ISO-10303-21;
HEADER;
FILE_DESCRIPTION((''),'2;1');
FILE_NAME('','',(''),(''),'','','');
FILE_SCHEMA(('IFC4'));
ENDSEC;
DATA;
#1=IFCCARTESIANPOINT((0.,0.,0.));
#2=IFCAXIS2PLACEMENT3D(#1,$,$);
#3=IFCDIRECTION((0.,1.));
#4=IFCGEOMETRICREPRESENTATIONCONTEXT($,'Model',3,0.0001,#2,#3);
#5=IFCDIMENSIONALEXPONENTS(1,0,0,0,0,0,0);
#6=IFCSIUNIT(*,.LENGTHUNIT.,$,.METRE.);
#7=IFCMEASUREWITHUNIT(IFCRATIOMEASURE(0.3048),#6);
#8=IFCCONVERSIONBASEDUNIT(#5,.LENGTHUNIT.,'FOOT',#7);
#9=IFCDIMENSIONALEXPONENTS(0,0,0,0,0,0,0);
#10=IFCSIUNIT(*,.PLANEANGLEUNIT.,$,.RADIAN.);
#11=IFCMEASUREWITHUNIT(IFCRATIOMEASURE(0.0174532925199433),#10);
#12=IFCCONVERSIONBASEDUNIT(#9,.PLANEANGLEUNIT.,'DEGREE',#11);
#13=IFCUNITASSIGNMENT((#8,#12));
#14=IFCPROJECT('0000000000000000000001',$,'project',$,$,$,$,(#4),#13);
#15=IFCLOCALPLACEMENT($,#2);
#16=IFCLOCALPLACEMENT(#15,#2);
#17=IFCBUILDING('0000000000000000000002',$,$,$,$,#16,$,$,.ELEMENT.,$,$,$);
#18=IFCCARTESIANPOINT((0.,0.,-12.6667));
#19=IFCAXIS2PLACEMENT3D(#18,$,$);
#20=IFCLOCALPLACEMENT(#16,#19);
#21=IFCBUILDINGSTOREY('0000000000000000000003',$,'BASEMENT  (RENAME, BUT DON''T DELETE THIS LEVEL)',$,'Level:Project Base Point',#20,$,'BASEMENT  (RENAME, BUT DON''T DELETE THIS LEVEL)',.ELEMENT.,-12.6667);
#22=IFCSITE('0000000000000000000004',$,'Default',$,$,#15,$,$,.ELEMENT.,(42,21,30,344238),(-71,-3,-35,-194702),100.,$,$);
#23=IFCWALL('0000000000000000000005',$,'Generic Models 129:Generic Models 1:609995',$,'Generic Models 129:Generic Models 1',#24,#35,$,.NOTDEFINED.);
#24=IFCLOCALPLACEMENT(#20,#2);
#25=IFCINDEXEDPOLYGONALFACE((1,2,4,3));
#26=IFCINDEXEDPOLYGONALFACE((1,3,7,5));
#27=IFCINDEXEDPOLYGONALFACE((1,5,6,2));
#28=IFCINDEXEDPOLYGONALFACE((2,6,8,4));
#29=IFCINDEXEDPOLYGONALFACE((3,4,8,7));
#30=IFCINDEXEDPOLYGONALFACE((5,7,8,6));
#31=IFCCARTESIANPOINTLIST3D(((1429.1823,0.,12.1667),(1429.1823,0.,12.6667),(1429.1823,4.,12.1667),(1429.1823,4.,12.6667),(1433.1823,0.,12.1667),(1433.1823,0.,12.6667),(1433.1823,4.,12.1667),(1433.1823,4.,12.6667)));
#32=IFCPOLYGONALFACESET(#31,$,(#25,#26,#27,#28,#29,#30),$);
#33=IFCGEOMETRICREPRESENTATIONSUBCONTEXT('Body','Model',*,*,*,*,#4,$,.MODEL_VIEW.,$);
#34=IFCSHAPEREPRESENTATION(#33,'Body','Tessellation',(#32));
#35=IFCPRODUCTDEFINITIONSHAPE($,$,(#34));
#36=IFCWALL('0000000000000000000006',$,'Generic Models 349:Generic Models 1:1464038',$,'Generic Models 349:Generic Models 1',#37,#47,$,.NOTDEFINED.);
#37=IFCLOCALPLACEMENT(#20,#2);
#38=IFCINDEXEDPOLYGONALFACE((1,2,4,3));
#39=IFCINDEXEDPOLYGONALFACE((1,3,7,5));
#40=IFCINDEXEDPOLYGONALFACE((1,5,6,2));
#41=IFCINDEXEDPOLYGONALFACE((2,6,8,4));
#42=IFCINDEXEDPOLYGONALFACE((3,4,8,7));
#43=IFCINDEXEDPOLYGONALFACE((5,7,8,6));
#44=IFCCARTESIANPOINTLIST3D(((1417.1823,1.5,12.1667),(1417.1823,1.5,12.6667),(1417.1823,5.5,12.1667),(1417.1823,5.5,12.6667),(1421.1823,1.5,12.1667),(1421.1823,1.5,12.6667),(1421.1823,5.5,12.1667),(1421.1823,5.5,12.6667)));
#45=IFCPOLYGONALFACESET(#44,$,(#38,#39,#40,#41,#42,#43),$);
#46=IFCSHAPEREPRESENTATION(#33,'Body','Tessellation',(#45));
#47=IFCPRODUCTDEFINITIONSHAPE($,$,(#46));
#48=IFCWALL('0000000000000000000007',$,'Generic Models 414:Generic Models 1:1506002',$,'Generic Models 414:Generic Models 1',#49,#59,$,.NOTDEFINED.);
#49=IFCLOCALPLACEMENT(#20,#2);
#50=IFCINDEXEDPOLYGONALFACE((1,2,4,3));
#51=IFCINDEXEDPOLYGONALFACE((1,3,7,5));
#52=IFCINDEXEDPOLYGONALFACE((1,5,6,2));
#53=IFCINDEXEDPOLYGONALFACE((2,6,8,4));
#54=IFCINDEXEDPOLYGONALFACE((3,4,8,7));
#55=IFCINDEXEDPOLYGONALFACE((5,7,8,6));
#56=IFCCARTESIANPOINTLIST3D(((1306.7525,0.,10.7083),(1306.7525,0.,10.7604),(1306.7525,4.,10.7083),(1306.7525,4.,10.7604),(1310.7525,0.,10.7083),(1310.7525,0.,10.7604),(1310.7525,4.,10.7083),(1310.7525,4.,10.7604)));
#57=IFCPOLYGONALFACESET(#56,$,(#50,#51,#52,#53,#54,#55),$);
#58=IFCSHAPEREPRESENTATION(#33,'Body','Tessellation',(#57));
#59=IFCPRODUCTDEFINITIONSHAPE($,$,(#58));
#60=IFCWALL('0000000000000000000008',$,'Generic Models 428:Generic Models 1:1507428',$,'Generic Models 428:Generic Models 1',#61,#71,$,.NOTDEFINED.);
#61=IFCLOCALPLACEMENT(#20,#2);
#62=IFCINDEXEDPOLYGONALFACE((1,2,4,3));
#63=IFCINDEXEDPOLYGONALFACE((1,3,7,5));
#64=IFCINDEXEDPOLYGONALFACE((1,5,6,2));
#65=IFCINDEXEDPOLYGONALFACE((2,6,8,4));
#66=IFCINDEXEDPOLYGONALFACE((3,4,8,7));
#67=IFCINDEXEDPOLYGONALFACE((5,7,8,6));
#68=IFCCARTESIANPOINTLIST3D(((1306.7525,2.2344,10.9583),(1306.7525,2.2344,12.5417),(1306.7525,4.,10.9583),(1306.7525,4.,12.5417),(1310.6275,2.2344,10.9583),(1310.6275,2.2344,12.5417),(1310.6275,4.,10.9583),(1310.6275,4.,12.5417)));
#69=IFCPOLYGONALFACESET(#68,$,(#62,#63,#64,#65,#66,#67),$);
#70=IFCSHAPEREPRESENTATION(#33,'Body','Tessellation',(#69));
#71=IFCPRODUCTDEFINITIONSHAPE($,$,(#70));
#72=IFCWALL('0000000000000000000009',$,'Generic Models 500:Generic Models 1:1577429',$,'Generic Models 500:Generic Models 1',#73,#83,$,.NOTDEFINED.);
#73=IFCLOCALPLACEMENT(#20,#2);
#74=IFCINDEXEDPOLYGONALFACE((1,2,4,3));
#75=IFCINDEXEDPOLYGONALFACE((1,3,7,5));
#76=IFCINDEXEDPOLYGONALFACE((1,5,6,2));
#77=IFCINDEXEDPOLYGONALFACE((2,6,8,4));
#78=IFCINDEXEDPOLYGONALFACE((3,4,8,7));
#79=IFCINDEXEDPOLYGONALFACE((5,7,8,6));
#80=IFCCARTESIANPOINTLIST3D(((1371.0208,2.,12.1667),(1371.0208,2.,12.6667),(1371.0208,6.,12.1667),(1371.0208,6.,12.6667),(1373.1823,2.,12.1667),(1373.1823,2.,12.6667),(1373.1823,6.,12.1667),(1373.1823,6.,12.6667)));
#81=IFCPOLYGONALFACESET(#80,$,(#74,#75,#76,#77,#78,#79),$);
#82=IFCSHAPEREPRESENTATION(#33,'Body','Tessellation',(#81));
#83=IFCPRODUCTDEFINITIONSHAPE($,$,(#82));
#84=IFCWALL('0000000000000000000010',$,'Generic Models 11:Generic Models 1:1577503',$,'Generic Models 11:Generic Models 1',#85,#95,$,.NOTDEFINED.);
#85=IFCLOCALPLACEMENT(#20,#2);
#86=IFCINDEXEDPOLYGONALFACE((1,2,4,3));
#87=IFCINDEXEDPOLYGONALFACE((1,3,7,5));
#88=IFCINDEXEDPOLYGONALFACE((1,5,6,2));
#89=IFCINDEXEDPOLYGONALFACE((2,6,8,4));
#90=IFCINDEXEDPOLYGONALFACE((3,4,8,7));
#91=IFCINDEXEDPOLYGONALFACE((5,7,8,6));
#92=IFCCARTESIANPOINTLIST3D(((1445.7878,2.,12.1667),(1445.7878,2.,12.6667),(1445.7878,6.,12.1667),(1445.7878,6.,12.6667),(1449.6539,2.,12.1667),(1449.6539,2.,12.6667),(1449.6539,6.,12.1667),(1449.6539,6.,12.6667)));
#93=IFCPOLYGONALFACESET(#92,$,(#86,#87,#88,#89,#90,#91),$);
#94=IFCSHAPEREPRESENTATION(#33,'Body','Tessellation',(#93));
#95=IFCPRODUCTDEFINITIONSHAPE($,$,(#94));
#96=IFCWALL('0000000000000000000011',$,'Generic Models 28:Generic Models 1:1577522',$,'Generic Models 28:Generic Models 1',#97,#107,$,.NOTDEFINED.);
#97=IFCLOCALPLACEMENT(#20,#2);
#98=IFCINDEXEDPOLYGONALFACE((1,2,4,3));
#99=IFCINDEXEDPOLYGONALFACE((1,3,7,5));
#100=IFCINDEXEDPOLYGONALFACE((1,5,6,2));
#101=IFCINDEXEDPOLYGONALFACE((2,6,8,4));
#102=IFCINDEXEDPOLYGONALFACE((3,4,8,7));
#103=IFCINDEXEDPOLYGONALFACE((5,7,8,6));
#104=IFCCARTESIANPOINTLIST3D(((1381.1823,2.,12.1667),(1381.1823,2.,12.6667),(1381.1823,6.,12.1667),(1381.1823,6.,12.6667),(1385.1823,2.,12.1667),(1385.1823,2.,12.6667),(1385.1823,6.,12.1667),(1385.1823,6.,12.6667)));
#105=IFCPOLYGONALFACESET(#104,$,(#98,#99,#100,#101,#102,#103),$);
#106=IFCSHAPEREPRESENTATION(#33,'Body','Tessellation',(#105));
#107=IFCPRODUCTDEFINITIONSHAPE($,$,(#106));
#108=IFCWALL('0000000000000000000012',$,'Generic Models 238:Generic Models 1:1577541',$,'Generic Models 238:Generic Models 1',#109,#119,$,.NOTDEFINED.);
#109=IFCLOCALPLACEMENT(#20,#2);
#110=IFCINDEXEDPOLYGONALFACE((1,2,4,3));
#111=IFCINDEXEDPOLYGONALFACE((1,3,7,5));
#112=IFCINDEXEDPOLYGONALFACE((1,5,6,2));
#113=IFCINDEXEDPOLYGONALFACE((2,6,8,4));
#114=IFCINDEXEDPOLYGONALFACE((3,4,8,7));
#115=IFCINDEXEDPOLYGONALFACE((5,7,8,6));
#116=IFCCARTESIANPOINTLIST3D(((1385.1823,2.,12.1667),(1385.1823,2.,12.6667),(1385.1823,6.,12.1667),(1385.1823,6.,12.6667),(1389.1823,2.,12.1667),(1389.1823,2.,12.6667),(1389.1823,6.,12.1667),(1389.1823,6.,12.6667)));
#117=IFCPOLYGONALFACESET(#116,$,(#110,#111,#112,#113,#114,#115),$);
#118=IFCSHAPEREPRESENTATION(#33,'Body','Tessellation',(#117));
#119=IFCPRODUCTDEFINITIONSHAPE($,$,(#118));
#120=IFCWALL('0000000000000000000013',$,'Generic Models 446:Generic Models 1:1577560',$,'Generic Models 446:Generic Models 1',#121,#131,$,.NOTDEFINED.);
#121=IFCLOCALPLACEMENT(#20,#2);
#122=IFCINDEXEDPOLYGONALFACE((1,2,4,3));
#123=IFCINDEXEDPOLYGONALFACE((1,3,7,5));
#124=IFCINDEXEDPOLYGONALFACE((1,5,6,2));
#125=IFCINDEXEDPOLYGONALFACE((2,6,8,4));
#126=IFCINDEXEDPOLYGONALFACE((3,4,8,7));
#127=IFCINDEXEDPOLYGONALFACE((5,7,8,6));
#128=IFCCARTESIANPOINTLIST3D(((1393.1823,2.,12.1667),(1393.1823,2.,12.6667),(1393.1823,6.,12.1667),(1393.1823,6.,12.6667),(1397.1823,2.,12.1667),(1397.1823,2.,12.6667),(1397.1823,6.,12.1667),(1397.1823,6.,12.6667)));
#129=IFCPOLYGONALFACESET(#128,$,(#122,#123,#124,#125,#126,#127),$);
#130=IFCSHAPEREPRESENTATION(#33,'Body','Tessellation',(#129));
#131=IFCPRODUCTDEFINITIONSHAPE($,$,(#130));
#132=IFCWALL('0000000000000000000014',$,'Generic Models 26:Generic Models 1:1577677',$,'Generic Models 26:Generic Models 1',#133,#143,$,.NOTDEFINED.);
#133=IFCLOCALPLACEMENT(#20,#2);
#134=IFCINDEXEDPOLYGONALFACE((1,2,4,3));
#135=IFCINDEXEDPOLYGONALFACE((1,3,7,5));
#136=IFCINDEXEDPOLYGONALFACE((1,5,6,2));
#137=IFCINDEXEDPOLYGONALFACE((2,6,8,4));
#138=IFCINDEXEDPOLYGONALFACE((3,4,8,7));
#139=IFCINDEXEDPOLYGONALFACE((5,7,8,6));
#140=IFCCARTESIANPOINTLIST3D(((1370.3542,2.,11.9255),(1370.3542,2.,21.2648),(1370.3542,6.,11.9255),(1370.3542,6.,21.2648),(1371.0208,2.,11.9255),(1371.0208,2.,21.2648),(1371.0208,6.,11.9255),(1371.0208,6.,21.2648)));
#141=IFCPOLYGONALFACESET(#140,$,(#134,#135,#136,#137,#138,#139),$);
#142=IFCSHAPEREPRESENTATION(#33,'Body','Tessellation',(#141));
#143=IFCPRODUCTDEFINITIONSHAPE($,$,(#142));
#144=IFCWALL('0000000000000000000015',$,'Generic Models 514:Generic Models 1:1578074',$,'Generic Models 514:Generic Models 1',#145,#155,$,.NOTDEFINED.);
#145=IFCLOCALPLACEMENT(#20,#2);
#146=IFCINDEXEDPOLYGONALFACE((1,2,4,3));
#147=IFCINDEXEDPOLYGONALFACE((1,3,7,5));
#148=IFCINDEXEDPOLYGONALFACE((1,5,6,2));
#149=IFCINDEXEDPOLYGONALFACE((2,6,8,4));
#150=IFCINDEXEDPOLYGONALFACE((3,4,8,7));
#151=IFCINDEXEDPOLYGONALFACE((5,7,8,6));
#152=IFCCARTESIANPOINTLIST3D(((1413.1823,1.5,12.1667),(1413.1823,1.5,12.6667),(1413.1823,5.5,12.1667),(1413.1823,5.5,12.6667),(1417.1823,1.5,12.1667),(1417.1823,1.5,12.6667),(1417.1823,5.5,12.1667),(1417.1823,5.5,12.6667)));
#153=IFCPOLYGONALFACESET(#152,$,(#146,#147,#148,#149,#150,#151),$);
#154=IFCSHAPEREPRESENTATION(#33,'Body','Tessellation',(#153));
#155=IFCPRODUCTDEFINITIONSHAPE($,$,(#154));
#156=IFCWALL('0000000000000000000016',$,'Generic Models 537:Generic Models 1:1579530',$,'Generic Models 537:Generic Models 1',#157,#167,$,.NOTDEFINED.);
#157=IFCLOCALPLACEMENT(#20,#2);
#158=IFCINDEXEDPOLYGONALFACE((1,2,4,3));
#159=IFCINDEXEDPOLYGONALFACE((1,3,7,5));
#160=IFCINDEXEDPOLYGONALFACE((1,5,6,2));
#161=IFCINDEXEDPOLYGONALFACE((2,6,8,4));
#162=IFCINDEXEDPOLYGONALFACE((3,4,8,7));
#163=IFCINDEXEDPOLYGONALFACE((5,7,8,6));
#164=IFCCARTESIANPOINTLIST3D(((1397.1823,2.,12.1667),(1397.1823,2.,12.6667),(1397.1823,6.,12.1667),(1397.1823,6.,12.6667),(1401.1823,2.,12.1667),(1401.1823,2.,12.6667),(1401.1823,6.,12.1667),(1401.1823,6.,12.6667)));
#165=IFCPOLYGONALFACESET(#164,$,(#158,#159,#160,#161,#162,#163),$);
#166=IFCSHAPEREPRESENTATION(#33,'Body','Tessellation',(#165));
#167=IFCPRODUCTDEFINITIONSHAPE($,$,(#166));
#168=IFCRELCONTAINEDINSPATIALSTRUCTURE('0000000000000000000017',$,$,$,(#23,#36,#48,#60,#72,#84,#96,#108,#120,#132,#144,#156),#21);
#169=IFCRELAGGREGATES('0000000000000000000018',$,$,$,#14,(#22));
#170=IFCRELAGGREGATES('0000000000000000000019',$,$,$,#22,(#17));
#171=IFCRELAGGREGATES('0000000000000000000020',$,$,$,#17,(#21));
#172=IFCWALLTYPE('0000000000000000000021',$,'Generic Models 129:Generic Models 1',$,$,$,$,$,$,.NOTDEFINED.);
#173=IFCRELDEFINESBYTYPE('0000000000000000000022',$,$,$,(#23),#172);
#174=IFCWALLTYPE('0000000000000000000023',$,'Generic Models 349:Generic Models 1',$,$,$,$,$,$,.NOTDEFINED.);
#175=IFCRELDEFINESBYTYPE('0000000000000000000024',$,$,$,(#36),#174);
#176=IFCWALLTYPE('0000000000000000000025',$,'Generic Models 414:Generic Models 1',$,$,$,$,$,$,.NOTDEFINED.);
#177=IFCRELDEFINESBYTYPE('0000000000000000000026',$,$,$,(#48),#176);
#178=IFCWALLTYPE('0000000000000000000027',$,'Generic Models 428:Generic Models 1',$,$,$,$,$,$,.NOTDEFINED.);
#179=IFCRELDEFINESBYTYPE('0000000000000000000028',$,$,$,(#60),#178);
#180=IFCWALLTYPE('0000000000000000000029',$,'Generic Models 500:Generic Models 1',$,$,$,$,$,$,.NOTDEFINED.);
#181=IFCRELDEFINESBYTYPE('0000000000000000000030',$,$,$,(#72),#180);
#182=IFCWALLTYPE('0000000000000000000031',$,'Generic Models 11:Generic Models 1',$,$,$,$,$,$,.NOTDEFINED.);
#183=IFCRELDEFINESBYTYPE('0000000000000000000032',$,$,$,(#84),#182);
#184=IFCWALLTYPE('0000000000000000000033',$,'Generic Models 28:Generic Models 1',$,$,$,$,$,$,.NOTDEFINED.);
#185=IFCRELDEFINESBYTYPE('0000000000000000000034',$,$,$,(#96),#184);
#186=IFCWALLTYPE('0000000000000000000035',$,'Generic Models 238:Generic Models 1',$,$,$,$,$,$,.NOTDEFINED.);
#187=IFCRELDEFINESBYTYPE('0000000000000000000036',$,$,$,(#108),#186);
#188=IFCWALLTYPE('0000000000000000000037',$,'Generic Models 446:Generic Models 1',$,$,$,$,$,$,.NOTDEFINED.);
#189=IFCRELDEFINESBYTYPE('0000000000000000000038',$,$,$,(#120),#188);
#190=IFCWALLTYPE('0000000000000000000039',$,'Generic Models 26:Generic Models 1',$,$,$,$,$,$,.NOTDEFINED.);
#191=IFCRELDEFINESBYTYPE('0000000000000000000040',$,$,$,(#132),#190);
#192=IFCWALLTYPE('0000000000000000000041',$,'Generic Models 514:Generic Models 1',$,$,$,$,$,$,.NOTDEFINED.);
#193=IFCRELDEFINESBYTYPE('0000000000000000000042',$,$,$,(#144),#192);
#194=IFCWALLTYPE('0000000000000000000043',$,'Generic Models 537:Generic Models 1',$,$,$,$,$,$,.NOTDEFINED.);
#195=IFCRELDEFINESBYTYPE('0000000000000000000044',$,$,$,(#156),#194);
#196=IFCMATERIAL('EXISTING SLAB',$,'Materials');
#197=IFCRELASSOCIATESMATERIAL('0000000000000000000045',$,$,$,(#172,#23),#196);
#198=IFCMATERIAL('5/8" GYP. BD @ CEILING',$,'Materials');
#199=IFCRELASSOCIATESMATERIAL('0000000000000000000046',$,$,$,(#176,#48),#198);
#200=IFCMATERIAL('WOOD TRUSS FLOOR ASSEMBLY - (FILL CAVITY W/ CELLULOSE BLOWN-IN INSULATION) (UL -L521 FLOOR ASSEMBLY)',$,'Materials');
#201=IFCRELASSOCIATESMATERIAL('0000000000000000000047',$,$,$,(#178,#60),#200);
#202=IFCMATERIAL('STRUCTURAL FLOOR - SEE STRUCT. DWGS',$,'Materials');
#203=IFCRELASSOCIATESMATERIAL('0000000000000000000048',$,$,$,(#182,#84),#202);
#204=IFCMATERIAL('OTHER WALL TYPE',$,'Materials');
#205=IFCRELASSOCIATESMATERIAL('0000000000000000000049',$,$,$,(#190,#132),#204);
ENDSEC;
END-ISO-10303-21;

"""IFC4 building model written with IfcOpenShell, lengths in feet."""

from ifc_helpers import new_model, entity, si_unit, converted_unit, direction, frame, frame_2d, origin, origin_2d_with_axis, place, context, subcontext, project, spatial, rectangle, extrude, material, type_object, element, save


model = new_model("IFC4")

# Units and contexts
model_context = context("Model", 3, precision=0.0001, world=origin(), true_north=direction((0.0, 1.0)))
body_context = subcontext(model_context, "Body", "Model", "MODEL_VIEW")
ifc_project = project(units=[converted_unit("LENGTHUNIT", "FOOT", entity("IfcRatioMeasure", 0.3048), si_unit("LENGTHUNIT", "METRE"), dimensions=[1, 0, 0, 0, 0, 0, 0]), converted_unit("PLANEANGLEUNIT", "DEGREE", entity("IfcRatioMeasure", 0.0174532925199433), si_unit("PLANEANGLEUNIT", "RADIAN"), dimensions=[0, 0, 0, 0, 0, 0, 0])], contexts=[model_context])

# Site, building, storey
site_placement = place(None, origin())
site = spatial("IfcSite", under=ifc_project, at=site_placement, Name="Default", CompositionType="ELEMENT", RefLatitude=(42, 21, 30, 344238), RefLongitude=(-71, -3, -35, -194702), RefElevation=100.0)
building_placement = place(site_placement, origin())
building = spatial("IfcBuilding", under=site, at=building_placement, CompositionType="ELEMENT")
storey_placement = place(building_placement, frame((0.0, 0.0, -12.6667)))
storey = spatial("IfcBuildingStorey", under=building, at=storey_placement, Name="BASEMENT  (RENAME, BUT DON'T DELETE THIS LEVEL)", ObjectType="Level:Project Base Point", LongName="BASEMENT  (RENAME, BUT DON'T DELETE THIS LEVEL)", CompositionType="ELEMENT", Elevation=-12.6667)

# Walls
ifc_material_1 = material(Name="EXISTING SLAB", Category="Materials")
wall_type_1 = type_object("IfcWallType", Name="Generic Models 129:Generic Models 1", PredefinedType="NOTDEFINED", material=ifc_material_1)
wall_1_placement = place(storey_placement, frame((1429.1823, 0.0, 12.1667), z_axis=(0.0, 0.0, 1.0), x_axis=(0.0, 1.0, 0.0)))
element("IfcWall", 1, at=wall_1_placement, inside=storey, type_object=wall_type_1, material=ifc_material_1, Name="Generic Models 129:Generic Models 1:609995", ObjectType="Generic Models 129:Generic Models 1", PredefinedType="NOTDEFINED", context=body_context, shape_type="SweptSolid", body=[
    extrude(rectangle(XDim=4.0, YDim=4.0, at=frame_2d((0.0, 0.0), x_axis=(1.0, 0.0))), frame((2.0, -2.0, 0.0)), (0.0, 0.0, 1.0), 0.5),
])
wall_type_2 = type_object("IfcWallType", Name="Generic Models 349:Generic Models 1", PredefinedType="NOTDEFINED")
wall_2_placement = place(storey_placement, frame((1417.1823, 1.5, 12.1667), z_axis=(0.0, 0.0, 1.0), x_axis=(0.0, 1.0, 0.0)))
element("IfcWall", 2, at=wall_2_placement, inside=storey, type_object=wall_type_2, Name="Generic Models 349:Generic Models 1:1464038", ObjectType="Generic Models 349:Generic Models 1", PredefinedType="NOTDEFINED", context=body_context, shape_type="SweptSolid", body=[
    extrude(rectangle(XDim=4.0, YDim=4.0, at=frame_2d((0.0, 0.0), x_axis=(1.0, 0.0))), frame((2.0, -2.0, 0.0)), (0.0, 0.0, 1.0), 0.5),
])
ifc_material_2 = material(Name="5/8\" GYP. BD @ CEILING", Category="Materials")
wall_type_3 = type_object("IfcWallType", Name="Generic Models 414:Generic Models 1", PredefinedType="NOTDEFINED", material=ifc_material_2)
wall_3_placement = place(storey_placement, frame((1306.7525, 0.0, 10.7083), z_axis=(0.0, 0.0, 1.0), x_axis=(0.0, 1.0, 0.0)))
element("IfcWall", 3, at=wall_3_placement, inside=storey, type_object=wall_type_3, material=ifc_material_2, Name="Generic Models 414:Generic Models 1:1506002", ObjectType="Generic Models 414:Generic Models 1", PredefinedType="NOTDEFINED", context=body_context, shape_type="SweptSolid", body=[
    extrude(rectangle(XDim=4.0, YDim=4.0, at=origin_2d_with_axis()), frame((2.0, -2.0, 0.0)), (0.0, 0.0, 1.0), 0.0521),
])
ifc_material_3 = material(Name="WOOD TRUSS FLOOR ASSEMBLY - (FILL CAVITY W/ CELLULOSE BLOWN-IN INSULATION) (UL -L521 FLOOR ASSEMBLY)", Category="Materials")
wall_type_4 = type_object("IfcWallType", Name="Generic Models 428:Generic Models 1", PredefinedType="NOTDEFINED", material=ifc_material_3)
wall_4_placement = place(storey_placement, frame((1306.7525, 2.2344, 10.9583)))
element("IfcWall", 4, at=wall_4_placement, inside=storey, type_object=wall_type_4, material=ifc_material_3, Name="Generic Models 428:Generic Models 1:1507428", ObjectType="Generic Models 428:Generic Models 1", PredefinedType="NOTDEFINED", context=body_context, shape_type="SweptSolid", body=[
    extrude(rectangle(XDim=1.7656, YDim=3.875, at=frame_2d((0.0, 0.0), x_axis=(1.0, 0.0))), frame((1.9375, 0.8828, 0.0), z_axis=(0.0, 0.0, 1.0), x_axis=(0.0, 1.0, 0.0)), (0.0, 0.0, 1.0), 1.5833),
])
wall_type_5 = type_object("IfcWallType", Name="Generic Models 500:Generic Models 1", PredefinedType="NOTDEFINED")
wall_5_placement = place(storey_placement, frame((1371.0208, 2.0, 12.1667), z_axis=(0.0, 0.0, 1.0), x_axis=(0.0, 1.0, 0.0)))
element("IfcWall", 5, at=wall_5_placement, inside=storey, type_object=wall_type_5, Name="Generic Models 500:Generic Models 1:1577429", ObjectType="Generic Models 500:Generic Models 1", PredefinedType="NOTDEFINED", context=body_context, shape_type="SweptSolid", body=[
    extrude(rectangle(XDim=4.0, YDim=2.1615, at=frame_2d((0.0, 0.0), x_axis=(1.0, 0.0))), frame((2.0, -1.0807, 0.0)), (0.0, 0.0, 1.0), 0.5),
])
ifc_material_4 = material(Name="STRUCTURAL FLOOR - SEE STRUCT. DWGS", Category="Materials")
wall_type_6 = type_object("IfcWallType", Name="Generic Models 11:Generic Models 1", PredefinedType="NOTDEFINED", material=ifc_material_4)
wall_6_placement = place(storey_placement, frame((1445.7878, 2.0, 12.1667), z_axis=(0.0, 0.0, 1.0), x_axis=(0.0, 1.0, 0.0)))
element("IfcWall", 6, at=wall_6_placement, inside=storey, type_object=wall_type_6, material=ifc_material_4, Name="Generic Models 11:Generic Models 1:1577503", ObjectType="Generic Models 11:Generic Models 1", PredefinedType="NOTDEFINED", context=body_context, shape_type="SweptSolid", body=[
    extrude(rectangle(XDim=4.0, YDim=3.8661, at=frame_2d((0.0, 0.0), x_axis=(1.0, 0.0))), frame((2.0, -1.9331, 0.0)), (0.0, 0.0, 1.0), 0.5),
])
wall_type_7 = type_object("IfcWallType", Name="Generic Models 28:Generic Models 1", PredefinedType="NOTDEFINED")
wall_7_placement = place(storey_placement, frame((1381.1823, 2.0, 12.1667), z_axis=(0.0, 0.0, 1.0), x_axis=(0.0, 1.0, 0.0)))
element("IfcWall", 7, at=wall_7_placement, inside=storey, type_object=wall_type_7, Name="Generic Models 28:Generic Models 1:1577522", ObjectType="Generic Models 28:Generic Models 1", PredefinedType="NOTDEFINED", context=body_context, shape_type="SweptSolid", body=[
    extrude(rectangle(XDim=4.0, YDim=4.0, at=frame_2d((0.0, 0.0), x_axis=(1.0, 0.0))), frame((2.0, -2.0, 0.0)), (0.0, 0.0, 1.0), 0.5),
])
wall_type_8 = type_object("IfcWallType", Name="Generic Models 238:Generic Models 1", PredefinedType="NOTDEFINED")
wall_8_placement = place(storey_placement, frame((1385.1823, 2.0, 12.1667), z_axis=(0.0, 0.0, 1.0), x_axis=(0.0, 1.0, 0.0)))
element("IfcWall", 8, at=wall_8_placement, inside=storey, type_object=wall_type_8, Name="Generic Models 238:Generic Models 1:1577541", ObjectType="Generic Models 238:Generic Models 1", PredefinedType="NOTDEFINED", context=body_context, shape_type="SweptSolid", body=[
    extrude(rectangle(XDim=4.0, YDim=4.0, at=frame_2d((0.0, 0.0), x_axis=(1.0, 0.0))), frame((2.0, -2.0, 0.0)), (0.0, 0.0, 1.0), 0.5),
])
wall_type_9 = type_object("IfcWallType", Name="Generic Models 446:Generic Models 1", PredefinedType="NOTDEFINED")
wall_9_placement = place(storey_placement, frame((1393.1823, 2.0, 12.1667), z_axis=(0.0, 0.0, 1.0), x_axis=(0.0, 1.0, 0.0)))
element("IfcWall", 9, at=wall_9_placement, inside=storey, type_object=wall_type_9, Name="Generic Models 446:Generic Models 1:1577560", ObjectType="Generic Models 446:Generic Models 1", PredefinedType="NOTDEFINED", context=body_context, shape_type="SweptSolid", body=[
    extrude(rectangle(XDim=4.0, YDim=4.0, at=origin_2d_with_axis()), frame((2.0, -2.0, 0.0)), (0.0, 0.0, 1.0), 0.5),
])
ifc_material_5 = material(Name="OTHER WALL TYPE", Category="Materials")
wall_type_10 = type_object("IfcWallType", Name="Generic Models 26:Generic Models 1", PredefinedType="NOTDEFINED", material=ifc_material_5)
wall_10_placement = place(storey_placement, frame((1370.3542, 2.0, 11.9255), z_axis=(0.0, 0.0, 1.0), x_axis=(0.0, 1.0, 0.0)))
element("IfcWall", 10, at=wall_10_placement, inside=storey, type_object=wall_type_10, material=ifc_material_5, Name="Generic Models 26:Generic Models 1:1577677", ObjectType="Generic Models 26:Generic Models 1", PredefinedType="NOTDEFINED", context=body_context, shape_type="SweptSolid", body=[
    extrude(rectangle(XDim=4.0, YDim=0.6667, at=frame_2d((0.0, 0.0), x_axis=(1.0, 0.0))), frame((2.0, -0.3333, 0.0)), (0.0, 0.0, 1.0), 9.3393),
])
wall_type_11 = type_object("IfcWallType", Name="Generic Models 514:Generic Models 1", PredefinedType="NOTDEFINED")
wall_11_placement = place(storey_placement, frame((1413.1823, 1.5, 12.1667), z_axis=(0.0, 0.0, 1.0), x_axis=(0.0, 1.0, 0.0)))
element("IfcWall", 11, at=wall_11_placement, inside=storey, type_object=wall_type_11, Name="Generic Models 514:Generic Models 1:1578074", ObjectType="Generic Models 514:Generic Models 1", PredefinedType="NOTDEFINED", context=body_context, shape_type="SweptSolid", body=[
    extrude(rectangle(XDim=4.0, YDim=4.0, at=frame_2d((0.0, 0.0), x_axis=(1.0, 0.0))), frame((2.0, -2.0, 0.0)), (0.0, 0.0, 1.0), 0.5),
])
wall_type_12 = type_object("IfcWallType", Name="Generic Models 537:Generic Models 1", PredefinedType="NOTDEFINED")
wall_12_placement = place(storey_placement, frame((1397.1823, 2.0, 12.1667), z_axis=(0.0, 0.0, 1.0), x_axis=(0.0, 1.0, 0.0)))
element("IfcWall", 12, at=wall_12_placement, inside=storey, type_object=wall_type_12, Name="Generic Models 537:Generic Models 1:1579530", ObjectType="Generic Models 537:Generic Models 1", PredefinedType="NOTDEFINED", context=body_context, shape_type="SweptSolid", body=[
    extrude(rectangle(XDim=4.0, YDim=4.0, at=origin_2d_with_axis()), frame((2.0, -2.0, 0.0)), (0.0, 0.0, 1.0), 0.5),
])

save(model, "model.ifc")
